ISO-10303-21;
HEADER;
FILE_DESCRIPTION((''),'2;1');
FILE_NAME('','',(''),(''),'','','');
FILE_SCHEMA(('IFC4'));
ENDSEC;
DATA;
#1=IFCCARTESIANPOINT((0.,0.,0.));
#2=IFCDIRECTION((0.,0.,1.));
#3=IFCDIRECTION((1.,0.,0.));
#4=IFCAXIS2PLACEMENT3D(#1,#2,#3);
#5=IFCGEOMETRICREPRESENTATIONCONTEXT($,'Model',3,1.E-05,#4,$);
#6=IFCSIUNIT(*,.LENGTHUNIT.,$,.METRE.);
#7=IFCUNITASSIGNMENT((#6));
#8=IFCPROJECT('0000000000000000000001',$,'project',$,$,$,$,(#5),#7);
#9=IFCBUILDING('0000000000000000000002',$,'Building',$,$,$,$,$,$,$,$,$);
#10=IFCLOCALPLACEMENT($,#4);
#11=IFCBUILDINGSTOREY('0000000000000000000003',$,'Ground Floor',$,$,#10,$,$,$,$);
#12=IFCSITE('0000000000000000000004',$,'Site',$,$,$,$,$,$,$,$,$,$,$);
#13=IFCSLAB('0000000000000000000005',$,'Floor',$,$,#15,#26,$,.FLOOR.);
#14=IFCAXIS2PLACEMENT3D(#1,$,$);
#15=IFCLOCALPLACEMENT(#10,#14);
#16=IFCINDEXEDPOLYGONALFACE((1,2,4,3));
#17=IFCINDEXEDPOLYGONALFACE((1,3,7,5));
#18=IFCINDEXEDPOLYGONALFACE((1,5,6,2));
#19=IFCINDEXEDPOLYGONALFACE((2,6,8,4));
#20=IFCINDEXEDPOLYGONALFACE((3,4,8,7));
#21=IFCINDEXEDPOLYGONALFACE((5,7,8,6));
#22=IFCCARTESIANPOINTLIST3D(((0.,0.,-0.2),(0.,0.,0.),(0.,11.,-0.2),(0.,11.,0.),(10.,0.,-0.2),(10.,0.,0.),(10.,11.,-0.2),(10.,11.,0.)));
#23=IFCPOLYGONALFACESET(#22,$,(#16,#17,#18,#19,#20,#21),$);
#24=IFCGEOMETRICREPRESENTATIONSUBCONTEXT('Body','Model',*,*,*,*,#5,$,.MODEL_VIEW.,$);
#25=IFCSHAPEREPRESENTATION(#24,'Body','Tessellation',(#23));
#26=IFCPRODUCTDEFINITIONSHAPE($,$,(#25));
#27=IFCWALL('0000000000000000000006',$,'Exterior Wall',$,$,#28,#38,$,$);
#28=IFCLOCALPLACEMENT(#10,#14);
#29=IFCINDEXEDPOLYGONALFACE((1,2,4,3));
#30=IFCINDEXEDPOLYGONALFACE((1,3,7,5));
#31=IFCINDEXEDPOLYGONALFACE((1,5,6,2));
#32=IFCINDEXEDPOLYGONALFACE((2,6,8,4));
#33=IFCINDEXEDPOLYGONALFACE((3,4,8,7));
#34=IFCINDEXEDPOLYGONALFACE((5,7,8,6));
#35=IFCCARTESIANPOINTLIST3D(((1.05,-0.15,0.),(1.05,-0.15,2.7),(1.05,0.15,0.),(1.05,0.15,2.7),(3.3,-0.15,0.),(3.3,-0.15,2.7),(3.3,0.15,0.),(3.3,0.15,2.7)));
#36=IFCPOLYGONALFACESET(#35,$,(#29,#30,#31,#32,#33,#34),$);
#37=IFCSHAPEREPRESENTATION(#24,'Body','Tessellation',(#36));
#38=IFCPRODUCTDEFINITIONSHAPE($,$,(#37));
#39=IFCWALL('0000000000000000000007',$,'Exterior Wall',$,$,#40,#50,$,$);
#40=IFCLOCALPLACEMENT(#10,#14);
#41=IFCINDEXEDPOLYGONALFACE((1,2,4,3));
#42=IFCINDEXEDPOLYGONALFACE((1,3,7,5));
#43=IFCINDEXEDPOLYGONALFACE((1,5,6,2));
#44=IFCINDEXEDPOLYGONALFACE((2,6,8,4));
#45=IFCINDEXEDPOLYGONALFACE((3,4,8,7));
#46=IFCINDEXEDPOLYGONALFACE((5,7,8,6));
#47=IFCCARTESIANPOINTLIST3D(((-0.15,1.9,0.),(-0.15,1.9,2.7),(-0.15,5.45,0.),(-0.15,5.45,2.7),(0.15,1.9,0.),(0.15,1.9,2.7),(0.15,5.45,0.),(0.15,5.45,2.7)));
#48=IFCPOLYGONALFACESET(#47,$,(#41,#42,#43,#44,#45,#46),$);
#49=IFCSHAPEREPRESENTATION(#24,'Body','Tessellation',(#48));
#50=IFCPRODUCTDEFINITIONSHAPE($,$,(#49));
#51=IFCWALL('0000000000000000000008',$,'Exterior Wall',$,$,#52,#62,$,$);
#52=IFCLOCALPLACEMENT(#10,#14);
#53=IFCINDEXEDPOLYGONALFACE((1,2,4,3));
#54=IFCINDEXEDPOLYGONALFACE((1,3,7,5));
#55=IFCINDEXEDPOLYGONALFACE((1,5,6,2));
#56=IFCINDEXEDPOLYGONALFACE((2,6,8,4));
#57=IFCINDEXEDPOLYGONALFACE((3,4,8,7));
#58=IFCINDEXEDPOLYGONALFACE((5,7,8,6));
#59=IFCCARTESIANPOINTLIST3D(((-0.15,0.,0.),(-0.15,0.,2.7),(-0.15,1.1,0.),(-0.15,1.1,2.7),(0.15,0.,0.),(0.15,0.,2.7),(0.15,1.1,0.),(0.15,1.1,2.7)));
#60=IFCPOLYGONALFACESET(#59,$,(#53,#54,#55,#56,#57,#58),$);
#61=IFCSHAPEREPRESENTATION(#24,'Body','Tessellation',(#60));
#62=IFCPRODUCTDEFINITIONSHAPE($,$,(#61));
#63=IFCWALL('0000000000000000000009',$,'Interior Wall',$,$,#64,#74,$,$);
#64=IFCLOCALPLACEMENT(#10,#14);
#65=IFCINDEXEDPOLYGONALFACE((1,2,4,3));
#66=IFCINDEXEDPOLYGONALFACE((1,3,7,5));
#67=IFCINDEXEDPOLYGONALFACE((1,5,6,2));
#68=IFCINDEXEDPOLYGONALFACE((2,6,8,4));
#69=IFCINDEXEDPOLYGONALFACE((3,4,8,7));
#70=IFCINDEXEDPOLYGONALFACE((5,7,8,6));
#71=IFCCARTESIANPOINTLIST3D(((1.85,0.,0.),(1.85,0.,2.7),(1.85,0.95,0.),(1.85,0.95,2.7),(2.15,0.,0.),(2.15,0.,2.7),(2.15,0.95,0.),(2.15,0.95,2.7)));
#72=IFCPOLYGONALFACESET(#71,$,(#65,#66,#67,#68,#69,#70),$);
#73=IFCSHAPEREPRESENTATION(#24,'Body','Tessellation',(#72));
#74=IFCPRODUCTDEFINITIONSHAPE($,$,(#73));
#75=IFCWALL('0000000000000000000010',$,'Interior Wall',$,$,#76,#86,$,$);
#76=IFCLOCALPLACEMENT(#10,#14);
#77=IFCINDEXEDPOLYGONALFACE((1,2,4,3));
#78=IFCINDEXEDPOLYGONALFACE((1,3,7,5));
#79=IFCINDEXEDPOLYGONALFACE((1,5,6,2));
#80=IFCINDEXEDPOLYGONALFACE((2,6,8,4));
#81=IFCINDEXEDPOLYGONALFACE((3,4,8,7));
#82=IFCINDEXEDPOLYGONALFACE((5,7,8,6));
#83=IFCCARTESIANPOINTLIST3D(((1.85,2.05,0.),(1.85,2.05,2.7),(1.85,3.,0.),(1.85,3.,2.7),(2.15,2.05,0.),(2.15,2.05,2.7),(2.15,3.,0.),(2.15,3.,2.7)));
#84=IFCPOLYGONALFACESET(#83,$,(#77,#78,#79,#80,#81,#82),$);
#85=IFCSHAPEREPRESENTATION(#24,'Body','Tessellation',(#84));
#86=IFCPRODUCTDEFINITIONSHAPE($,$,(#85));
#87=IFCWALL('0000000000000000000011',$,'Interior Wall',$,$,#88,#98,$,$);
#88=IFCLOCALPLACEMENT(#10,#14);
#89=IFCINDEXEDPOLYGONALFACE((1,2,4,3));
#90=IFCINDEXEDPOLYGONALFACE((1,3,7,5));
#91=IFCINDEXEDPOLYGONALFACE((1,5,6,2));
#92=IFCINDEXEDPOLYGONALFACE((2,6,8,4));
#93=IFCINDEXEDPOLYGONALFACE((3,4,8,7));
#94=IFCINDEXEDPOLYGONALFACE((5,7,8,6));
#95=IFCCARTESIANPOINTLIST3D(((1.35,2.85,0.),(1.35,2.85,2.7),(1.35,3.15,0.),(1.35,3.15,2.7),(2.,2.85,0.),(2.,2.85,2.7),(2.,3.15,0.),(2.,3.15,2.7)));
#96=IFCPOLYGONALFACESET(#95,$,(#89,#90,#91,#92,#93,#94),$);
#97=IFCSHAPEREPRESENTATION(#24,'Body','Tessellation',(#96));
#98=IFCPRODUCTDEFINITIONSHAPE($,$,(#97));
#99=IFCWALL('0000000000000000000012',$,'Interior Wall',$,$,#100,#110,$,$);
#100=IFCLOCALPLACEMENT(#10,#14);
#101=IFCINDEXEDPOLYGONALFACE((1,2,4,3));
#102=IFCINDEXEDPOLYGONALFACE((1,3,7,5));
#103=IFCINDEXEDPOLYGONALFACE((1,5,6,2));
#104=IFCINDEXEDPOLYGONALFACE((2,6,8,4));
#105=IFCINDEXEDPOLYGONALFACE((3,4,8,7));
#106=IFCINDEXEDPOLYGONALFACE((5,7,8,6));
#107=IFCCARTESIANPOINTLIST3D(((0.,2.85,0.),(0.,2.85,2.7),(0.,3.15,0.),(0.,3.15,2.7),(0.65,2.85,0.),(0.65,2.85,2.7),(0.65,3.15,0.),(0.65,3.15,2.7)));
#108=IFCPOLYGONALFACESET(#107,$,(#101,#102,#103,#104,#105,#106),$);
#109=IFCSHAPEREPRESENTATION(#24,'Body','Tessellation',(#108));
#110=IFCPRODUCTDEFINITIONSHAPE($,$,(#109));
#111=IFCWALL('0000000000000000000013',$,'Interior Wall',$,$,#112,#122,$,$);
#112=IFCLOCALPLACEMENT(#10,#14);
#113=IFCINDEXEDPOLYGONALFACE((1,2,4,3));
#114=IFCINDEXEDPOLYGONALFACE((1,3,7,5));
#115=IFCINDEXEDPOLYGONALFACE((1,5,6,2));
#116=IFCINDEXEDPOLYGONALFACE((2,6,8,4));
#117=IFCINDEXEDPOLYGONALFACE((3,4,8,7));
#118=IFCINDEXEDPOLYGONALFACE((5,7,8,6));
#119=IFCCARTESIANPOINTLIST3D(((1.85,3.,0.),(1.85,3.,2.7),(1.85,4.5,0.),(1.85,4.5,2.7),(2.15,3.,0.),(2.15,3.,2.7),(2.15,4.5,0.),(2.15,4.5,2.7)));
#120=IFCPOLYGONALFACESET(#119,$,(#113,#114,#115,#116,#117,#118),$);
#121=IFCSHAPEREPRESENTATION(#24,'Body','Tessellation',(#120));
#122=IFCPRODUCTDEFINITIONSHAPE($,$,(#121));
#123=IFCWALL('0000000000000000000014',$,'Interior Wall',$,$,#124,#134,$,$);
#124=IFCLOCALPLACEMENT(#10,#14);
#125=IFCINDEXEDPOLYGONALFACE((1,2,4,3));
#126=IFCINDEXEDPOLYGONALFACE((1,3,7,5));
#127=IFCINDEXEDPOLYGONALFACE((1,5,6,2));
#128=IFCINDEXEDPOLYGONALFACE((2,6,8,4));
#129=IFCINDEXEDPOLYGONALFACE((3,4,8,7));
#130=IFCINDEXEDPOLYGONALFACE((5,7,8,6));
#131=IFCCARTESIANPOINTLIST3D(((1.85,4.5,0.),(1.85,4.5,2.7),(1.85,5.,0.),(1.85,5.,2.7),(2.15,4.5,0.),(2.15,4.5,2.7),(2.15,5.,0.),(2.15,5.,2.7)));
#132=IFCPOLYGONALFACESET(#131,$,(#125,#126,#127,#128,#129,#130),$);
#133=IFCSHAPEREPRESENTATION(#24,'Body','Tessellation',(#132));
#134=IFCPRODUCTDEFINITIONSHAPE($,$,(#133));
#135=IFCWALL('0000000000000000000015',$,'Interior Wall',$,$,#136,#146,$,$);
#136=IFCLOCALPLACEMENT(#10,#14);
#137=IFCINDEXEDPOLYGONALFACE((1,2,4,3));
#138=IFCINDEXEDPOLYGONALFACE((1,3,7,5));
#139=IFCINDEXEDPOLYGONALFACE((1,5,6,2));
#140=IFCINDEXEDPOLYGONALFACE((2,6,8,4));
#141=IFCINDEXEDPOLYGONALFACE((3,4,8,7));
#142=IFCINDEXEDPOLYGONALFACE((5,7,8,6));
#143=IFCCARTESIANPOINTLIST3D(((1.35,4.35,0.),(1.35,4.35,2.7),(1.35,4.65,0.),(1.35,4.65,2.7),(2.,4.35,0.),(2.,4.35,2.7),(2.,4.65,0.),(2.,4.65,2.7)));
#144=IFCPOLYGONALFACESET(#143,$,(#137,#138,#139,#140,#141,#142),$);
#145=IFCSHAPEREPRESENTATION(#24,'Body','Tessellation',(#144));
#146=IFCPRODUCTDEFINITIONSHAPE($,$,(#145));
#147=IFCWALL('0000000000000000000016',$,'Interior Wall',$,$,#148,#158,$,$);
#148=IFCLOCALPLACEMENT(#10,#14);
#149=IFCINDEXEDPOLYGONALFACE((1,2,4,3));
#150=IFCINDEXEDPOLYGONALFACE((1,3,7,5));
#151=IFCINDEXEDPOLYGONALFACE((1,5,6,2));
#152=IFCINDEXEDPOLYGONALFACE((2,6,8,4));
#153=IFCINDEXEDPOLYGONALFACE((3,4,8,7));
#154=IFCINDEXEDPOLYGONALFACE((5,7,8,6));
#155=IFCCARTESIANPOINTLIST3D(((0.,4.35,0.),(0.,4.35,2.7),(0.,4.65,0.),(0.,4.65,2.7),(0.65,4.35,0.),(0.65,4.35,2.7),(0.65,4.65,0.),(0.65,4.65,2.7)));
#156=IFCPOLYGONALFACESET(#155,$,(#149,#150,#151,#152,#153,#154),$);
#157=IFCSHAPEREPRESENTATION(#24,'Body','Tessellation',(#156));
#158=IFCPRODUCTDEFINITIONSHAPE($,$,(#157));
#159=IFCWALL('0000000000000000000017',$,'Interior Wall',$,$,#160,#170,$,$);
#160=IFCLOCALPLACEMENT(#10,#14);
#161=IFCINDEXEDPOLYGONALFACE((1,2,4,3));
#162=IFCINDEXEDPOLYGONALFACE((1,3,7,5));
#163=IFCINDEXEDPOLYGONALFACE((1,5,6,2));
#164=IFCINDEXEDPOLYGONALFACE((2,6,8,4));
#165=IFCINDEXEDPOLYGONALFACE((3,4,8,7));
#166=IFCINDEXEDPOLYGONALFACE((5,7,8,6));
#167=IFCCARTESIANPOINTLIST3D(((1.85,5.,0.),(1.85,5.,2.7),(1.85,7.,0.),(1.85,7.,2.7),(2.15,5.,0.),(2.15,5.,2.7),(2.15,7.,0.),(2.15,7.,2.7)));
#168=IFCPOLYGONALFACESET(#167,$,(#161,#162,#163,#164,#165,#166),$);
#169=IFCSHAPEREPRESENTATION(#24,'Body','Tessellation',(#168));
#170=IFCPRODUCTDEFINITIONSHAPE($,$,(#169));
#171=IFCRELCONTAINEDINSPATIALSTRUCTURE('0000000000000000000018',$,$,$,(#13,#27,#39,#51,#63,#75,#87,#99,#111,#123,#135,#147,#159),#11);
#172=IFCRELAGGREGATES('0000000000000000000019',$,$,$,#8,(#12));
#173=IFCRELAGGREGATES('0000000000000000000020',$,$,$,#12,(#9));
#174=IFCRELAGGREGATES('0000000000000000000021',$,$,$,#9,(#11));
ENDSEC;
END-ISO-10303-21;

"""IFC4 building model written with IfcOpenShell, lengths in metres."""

from ifc_helpers import new_model, si_unit, frame, origin_with_axes, place, context, subcontext, project, spatial, indexed_curve, outline, extrude, element, save


model = new_model("IFC4")

# Units and contexts
model_context = context("Model", 3, precision=1e-05, world=origin_with_axes())
body_context = subcontext(model_context, "Body", "Model", "MODEL_VIEW")
ifc_project = project(units=[si_unit("LENGTHUNIT", "METRE")], contexts=[model_context])

# Site, building, storey
site = spatial("IfcSite", under=ifc_project, Name="Site")
building = spatial("IfcBuilding", under=site, Name="Building")
storey_placement = place(None, origin_with_axes())
storey = spatial("IfcBuildingStorey", under=building, at=storey_placement, Name="Ground Floor")

# Slab
slab_placement = place(storey_placement, frame((0.0, 0.0, -0.2), z_axis=(0.0, 0.0, 1.0), x_axis=(1.0, 0.0, 0.0)))
element("IfcSlab", 1, at=slab_placement, inside=storey, Name="Floor", PredefinedType="FLOOR", context=body_context, shape_type="SweptSolid", body=[
    extrude(outline(indexed_curve([(0.0, 0.0), (10.0, 0.0), (10.0, 11.0), (0.0, 11.0)])), None, (0.0, 0.0, 1.0), 0.2),
])

# Walls
wall_1_placement = place(storey_placement, frame((1.05, 0.0, 0.0), z_axis=(0.0, 0.0, 1.0), x_axis=(1.0, 0.0, 0.0)))
element("IfcWall", 2, at=wall_1_placement, inside=storey, Name="Exterior Wall", context=body_context, shape_type="SweptSolid", body=[
    extrude(outline(indexed_curve([(0.0, 0.0), (0.0, 0.3), (2.25, 0.3), (2.25, 0.0), (0.0, 0.0)], self_intersect=False)), frame((0.0, -0.15, 0.0), z_axis=(0.0, 0.0, 1.0), x_axis=(1.0, 0.0, 0.0)), (0.0, 0.0, 1.0), 2.7),
])
wall_2_placement = place(storey_placement, frame((0.0, 5.45, 0.0), z_axis=(0.0, 0.0, 1.0), x_axis=(0.0, -1.0, 0.0)))
element("IfcWall", 3, at=wall_2_placement, inside=storey, Name="Exterior Wall", context=body_context, shape_type="SweptSolid", body=[
    extrude(outline(indexed_curve([(0.0, 0.0), (0.0, 0.3), (3.55, 0.3), (3.55, 0.0), (0.0, 0.0)], self_intersect=False)), frame((0.0, -0.15, 0.0), z_axis=(0.0, 0.0, 1.0), x_axis=(1.0, 0.0, 0.0)), (0.0, 0.0, 1.0), 2.7),
])
wall_3_placement = place(storey_placement, frame((0.0, 1.1, 0.0), z_axis=(0.0, 0.0, 1.0), x_axis=(0.0, -1.0, 0.0)))
element("IfcWall", 4, at=wall_3_placement, inside=storey, Name="Exterior Wall", context=body_context, shape_type="SweptSolid", body=[
    extrude(outline(indexed_curve([(0.0, 0.0), (0.0, 0.3), (1.1, 0.3), (1.1, 0.0), (0.0, 0.0)], self_intersect=False)), frame((0.0, -0.15, 0.0), z_axis=(0.0, 0.0, 1.0), x_axis=(1.0, 0.0, 0.0)), (0.0, 0.0, 1.0), 2.7),
])
wall_4_placement = place(storey_placement, frame((2.0, 0.0, 0.0), z_axis=(0.0, 0.0, 1.0), x_axis=(0.0, 1.0, 0.0)))
element("IfcWall", 5, at=wall_4_placement, inside=storey, Name="Interior Wall", context=body_context, shape_type="SweptSolid", body=[
    extrude(outline(indexed_curve([(0.0, 0.0), (0.0, 0.3), (0.95, 0.3), (0.95, 0.0), (0.0, 0.0)], self_intersect=False)), frame((0.0, -0.15, 0.0), z_axis=(0.0, 0.0, 1.0), x_axis=(1.0, 0.0, 0.0)), (0.0, 0.0, 1.0), 2.7),
])
wall_5_placement = place(storey_placement, frame((2.0, 2.05, 0.0), z_axis=(0.0, 0.0, 1.0), x_axis=(0.0, 1.0, 0.0)))
element("IfcWall", 6, at=wall_5_placement, inside=storey, Name="Interior Wall", context=body_context, shape_type="SweptSolid", body=[
    extrude(outline(indexed_curve([(0.0, 0.0), (0.0, 0.3), (0.95, 0.3), (0.95, 0.0), (0.0, 0.0)], self_intersect=False)), frame((0.0, -0.15, 0.0), z_axis=(0.0, 0.0, 1.0), x_axis=(1.0, 0.0, 0.0)), (0.0, 0.0, 1.0), 2.7),
])
for number, where, z_axis, x_axis, name in (
    (7, (2.0, 3.0, 0.0), (0.0, 0.0, 1.0), (-1.0, 0.0, 0.0), "Interior Wall"),
    (8, (0.65, 3.0, 0.0), (0.0, 0.0, 1.0), (-1.0, 0.0, 0.0), "Interior Wall"),
):
    element("IfcWall", number, at=place(storey_placement, frame(where, z_axis=z_axis, x_axis=x_axis)), inside=storey, Name=name, context=body_context, shape_type="SweptSolid", body=[
        extrude(outline(indexed_curve([(0.0, 0.0), (0.0, 0.3), (0.65, 0.3), (0.65, 0.0), (0.0, 0.0)], self_intersect=False)), frame((0.0, -0.15, 0.0), z_axis=(0.0, 0.0, 1.0), x_axis=(1.0, 0.0, 0.0)), (0.0, 0.0, 1.0), 2.7),
    ])
wall_6_placement = place(storey_placement, frame((2.0, 4.5, 0.0), z_axis=(0.0, 0.0, 1.0), x_axis=(0.0, -1.0, 0.0)))
element("IfcWall", 9, at=wall_6_placement, inside=storey, Name="Interior Wall", context=body_context, shape_type="SweptSolid", body=[
    extrude(outline(indexed_curve([(0.0, 0.0), (0.0, 0.3), (1.5, 0.3), (1.5, 0.0), (0.0, 0.0)], self_intersect=False)), frame((0.0, -0.15, 0.0), z_axis=(0.0, 0.0, 1.0), x_axis=(1.0, 0.0, 0.0)), (0.0, 0.0, 1.0), 2.7),
])
wall_7_placement = place(storey_placement, frame((2.0, 5.0, 0.0), z_axis=(0.0, 0.0, 1.0), x_axis=(0.0, -1.0, 0.0)))
element("IfcWall", 10, at=wall_7_placement, inside=storey, Name="Interior Wall", context=body_context, shape_type="SweptSolid", body=[
    extrude(outline(indexed_curve([(0.0, 0.0), (0.0, 0.3), (0.5, 0.3), (0.5, 0.0), (0.0, 0.0)], self_intersect=False)), frame((0.0, -0.15, 0.0), z_axis=(0.0, 0.0, 1.0), x_axis=(1.0, 0.0, 0.0)), (0.0, 0.0, 1.0), 2.7),
])
for number, where, z_axis, x_axis, name in (
    (11, (2.0, 4.5, 0.0), (0.0, 0.0, 1.0), (-1.0, 0.0, 0.0), "Interior Wall"),
    (12, (0.65, 4.5, 0.0), (0.0, 0.0, 1.0), (-1.0, 0.0, 0.0), "Interior Wall"),
):
    element("IfcWall", number, at=place(storey_placement, frame(where, z_axis=z_axis, x_axis=x_axis)), inside=storey, Name=name, context=body_context, shape_type="SweptSolid", body=[
        extrude(outline(indexed_curve([(0.0, 0.0), (0.0, 0.3), (0.65, 0.3), (0.65, 0.0), (0.0, 0.0)], self_intersect=False)), frame((0.0, -0.15, 0.0), z_axis=(0.0, 0.0, 1.0), x_axis=(1.0, 0.0, 0.0)), (0.0, 0.0, 1.0), 2.7),
    ])
wall_8_placement = place(storey_placement, frame((2.0, 5.0, 0.0), z_axis=(0.0, 0.0, 1.0), x_axis=(0.0, 1.0, 0.0)))
element("IfcWall", 13, at=wall_8_placement, inside=storey, Name="Interior Wall", context=body_context, shape_type="SweptSolid", body=[
    extrude(outline(indexed_curve([(0.0, 0.0), (0.0, 0.3), (2.0, 0.3), (2.0, 0.0), (0.0, 0.0)], self_intersect=False)), frame((0.0, -0.15, 0.0), z_axis=(0.0, 0.0, 1.0), x_axis=(1.0, 0.0, 0.0)), (0.0, 0.0, 1.0), 2.7),
])

save(model, "model.ifc")
